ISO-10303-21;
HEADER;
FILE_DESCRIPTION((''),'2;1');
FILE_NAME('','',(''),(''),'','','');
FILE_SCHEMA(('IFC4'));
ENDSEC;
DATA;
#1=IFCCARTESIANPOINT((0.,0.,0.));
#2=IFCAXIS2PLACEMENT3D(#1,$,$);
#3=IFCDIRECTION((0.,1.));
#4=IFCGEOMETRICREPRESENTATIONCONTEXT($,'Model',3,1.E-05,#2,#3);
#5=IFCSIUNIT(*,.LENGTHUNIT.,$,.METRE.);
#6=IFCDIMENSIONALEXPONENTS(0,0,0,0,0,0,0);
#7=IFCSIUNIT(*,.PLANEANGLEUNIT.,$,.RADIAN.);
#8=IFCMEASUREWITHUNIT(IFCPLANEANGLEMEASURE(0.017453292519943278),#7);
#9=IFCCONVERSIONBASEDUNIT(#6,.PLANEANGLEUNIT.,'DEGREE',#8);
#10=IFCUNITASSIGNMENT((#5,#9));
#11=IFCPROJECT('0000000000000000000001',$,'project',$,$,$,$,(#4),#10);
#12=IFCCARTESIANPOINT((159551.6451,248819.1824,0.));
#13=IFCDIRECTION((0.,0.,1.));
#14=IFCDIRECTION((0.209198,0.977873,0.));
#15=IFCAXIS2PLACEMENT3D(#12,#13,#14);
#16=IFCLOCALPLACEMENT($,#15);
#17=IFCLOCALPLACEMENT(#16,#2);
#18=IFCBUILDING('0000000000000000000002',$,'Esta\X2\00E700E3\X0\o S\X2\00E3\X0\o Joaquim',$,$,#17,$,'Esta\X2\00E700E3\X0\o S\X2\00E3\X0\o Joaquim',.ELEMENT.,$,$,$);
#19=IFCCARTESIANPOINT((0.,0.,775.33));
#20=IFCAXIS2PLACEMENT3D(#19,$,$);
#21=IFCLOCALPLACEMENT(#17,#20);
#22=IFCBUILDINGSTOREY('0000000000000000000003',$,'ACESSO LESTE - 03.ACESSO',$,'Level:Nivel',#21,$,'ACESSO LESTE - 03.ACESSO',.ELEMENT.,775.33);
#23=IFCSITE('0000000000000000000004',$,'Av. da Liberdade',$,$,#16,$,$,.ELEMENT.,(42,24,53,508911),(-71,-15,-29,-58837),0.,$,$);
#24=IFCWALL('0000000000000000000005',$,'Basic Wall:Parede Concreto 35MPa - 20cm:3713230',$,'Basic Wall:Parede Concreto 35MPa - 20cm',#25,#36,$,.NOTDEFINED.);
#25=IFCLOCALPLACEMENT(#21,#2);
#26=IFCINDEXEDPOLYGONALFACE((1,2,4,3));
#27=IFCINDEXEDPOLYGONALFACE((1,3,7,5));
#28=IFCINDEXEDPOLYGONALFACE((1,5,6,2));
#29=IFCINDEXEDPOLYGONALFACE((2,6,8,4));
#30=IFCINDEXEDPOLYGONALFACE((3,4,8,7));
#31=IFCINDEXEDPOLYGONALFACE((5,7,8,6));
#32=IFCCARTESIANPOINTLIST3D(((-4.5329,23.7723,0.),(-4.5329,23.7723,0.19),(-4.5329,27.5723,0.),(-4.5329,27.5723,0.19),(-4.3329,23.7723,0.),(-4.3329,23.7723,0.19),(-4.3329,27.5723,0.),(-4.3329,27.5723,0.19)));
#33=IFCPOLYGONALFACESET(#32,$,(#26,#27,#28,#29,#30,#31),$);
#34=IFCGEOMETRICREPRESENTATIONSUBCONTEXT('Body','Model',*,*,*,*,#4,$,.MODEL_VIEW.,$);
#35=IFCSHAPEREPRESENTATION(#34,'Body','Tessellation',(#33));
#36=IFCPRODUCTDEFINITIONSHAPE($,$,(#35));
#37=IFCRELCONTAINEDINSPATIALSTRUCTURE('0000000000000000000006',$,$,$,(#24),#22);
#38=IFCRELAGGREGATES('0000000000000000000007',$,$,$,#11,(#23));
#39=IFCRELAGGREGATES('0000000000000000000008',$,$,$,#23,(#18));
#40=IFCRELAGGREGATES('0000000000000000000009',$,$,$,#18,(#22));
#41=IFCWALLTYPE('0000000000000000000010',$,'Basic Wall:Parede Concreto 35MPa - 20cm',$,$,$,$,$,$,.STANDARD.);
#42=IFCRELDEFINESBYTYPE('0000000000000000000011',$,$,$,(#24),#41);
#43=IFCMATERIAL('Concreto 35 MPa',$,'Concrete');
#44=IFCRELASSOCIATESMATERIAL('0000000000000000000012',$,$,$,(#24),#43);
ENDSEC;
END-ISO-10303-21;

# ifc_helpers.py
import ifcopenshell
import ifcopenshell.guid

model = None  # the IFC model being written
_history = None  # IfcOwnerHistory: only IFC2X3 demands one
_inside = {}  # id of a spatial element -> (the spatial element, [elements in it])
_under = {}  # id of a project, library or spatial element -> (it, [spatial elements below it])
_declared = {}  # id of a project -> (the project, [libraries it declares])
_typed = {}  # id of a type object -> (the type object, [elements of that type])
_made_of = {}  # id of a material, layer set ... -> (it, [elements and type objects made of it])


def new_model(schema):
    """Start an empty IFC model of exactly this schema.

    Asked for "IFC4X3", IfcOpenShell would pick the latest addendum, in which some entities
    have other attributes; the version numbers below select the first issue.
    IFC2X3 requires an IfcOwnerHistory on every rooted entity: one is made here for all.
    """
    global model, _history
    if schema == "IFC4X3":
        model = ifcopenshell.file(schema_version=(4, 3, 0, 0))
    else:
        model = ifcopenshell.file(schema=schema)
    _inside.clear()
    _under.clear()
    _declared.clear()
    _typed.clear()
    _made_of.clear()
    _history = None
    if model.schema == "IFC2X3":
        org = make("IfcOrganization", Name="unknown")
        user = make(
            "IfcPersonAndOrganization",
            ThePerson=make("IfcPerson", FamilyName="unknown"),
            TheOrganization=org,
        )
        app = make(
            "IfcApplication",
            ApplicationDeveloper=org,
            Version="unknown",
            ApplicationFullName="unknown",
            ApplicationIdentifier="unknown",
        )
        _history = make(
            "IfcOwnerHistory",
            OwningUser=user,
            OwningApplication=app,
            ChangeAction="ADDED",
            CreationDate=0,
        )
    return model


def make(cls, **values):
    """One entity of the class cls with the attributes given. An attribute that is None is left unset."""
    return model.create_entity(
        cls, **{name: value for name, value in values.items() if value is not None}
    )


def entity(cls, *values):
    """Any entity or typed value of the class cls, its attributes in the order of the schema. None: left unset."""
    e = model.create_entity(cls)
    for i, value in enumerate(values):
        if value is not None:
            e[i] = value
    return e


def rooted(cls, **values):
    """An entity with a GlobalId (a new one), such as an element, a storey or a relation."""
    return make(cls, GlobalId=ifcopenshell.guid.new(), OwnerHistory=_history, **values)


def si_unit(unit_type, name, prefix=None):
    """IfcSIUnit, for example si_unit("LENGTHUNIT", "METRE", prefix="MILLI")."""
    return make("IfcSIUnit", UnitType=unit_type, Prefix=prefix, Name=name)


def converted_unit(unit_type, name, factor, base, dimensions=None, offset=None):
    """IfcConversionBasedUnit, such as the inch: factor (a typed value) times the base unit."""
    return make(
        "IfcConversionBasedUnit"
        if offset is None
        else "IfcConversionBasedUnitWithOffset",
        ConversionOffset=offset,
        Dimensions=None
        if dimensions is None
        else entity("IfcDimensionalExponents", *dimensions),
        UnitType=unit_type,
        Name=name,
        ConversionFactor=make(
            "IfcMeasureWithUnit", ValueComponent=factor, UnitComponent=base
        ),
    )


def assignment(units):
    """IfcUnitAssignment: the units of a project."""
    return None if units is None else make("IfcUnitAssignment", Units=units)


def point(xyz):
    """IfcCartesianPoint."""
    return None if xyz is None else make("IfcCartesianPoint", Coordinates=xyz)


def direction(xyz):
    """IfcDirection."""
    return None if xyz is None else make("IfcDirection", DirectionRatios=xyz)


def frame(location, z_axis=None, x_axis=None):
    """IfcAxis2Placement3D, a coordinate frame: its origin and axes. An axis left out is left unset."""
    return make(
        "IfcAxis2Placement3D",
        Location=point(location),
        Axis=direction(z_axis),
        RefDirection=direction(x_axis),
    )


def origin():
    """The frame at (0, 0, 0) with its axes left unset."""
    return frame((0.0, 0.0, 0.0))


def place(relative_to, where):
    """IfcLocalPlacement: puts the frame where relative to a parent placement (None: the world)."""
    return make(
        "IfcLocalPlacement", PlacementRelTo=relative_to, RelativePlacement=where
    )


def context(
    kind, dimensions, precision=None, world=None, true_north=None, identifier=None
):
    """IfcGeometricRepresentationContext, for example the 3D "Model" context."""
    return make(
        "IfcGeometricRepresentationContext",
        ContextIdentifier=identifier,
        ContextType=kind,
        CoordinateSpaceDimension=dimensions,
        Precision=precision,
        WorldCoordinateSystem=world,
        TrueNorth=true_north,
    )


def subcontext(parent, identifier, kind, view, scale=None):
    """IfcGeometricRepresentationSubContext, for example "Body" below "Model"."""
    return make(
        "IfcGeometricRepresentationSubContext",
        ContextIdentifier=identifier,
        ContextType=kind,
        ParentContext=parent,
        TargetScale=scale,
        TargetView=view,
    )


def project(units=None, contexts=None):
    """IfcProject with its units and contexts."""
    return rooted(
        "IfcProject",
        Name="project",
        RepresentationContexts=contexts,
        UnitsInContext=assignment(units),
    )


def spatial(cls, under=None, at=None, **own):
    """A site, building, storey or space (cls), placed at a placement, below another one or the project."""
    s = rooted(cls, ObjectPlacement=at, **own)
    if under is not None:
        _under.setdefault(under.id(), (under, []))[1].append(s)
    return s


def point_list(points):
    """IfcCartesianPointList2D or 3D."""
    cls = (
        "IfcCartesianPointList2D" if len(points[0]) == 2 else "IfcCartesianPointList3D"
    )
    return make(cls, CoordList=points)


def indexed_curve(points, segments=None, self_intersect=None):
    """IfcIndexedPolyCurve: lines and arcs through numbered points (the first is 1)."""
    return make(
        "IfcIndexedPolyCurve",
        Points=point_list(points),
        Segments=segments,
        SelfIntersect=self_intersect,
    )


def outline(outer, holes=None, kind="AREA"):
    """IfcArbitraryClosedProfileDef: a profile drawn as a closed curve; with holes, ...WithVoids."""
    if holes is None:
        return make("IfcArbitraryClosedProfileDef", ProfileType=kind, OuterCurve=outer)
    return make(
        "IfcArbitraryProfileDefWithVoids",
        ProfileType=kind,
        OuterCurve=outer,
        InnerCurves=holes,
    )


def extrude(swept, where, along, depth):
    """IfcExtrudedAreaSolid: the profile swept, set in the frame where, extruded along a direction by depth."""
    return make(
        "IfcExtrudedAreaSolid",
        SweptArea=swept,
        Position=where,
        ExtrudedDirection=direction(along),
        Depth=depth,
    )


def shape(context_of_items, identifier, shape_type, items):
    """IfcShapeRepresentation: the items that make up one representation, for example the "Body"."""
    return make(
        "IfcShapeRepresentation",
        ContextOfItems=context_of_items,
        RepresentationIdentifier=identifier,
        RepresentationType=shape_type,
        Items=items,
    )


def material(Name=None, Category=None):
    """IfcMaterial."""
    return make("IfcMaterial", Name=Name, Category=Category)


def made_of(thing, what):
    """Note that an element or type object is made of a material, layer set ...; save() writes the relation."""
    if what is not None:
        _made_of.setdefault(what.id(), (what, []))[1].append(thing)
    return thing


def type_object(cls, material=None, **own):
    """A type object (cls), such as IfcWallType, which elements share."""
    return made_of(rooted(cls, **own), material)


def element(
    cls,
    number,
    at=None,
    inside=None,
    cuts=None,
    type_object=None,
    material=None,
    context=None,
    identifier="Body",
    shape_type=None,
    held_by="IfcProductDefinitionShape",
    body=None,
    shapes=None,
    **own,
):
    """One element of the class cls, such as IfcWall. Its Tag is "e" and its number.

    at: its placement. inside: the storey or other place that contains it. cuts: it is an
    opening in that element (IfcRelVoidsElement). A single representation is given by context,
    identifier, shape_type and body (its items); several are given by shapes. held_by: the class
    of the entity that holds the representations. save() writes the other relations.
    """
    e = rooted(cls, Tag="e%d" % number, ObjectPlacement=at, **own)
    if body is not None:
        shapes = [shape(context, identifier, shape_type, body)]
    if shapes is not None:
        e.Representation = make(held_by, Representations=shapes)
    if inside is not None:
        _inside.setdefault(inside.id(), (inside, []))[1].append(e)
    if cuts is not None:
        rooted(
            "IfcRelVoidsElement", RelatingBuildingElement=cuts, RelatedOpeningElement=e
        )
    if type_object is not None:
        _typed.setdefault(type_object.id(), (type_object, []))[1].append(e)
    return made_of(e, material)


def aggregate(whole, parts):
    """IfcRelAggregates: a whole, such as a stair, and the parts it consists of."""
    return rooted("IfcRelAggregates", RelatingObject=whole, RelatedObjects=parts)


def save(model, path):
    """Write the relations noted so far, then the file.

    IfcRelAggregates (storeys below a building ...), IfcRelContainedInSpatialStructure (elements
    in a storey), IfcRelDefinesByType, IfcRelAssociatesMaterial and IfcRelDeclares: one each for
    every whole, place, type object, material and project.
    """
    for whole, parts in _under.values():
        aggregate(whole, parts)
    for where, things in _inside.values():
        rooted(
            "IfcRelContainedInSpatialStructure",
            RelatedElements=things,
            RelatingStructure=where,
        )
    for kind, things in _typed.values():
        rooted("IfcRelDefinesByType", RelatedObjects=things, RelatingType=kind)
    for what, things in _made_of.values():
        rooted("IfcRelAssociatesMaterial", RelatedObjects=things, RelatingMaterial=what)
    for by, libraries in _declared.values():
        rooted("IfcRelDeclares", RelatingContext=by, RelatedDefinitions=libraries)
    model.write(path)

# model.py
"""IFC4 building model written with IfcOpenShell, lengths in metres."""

from ifc_helpers import new_model, entity, si_unit, converted_unit, direction, frame, origin, place, context, subcontext, project, spatial, indexed_curve, outline, extrude, material, type_object, element, save


model = new_model("IFC4")

# Units and contexts
model_context = context("Model", 3, precision=1e-05, world=origin(), true_north=direction((0.0, 1.0)))
body_context = subcontext(model_context, "Body", "Model", "MODEL_VIEW")
ifc_project = project(units=[si_unit("LENGTHUNIT", "METRE"), converted_unit("PLANEANGLEUNIT", "DEGREE", entity("IfcPlaneAngleMeasure", 0.017453292519943278), si_unit("PLANEANGLEUNIT", "RADIAN"), dimensions=[0, 0, 0, 0, 0, 0, 0])], contexts=[model_context])

# Site, building, storey
site_placement = place(None, frame((159551.6451, 248819.1824, 0.0), z_axis=(0.0, 0.0, 1.0), x_axis=(0.209198, 0.977873, 0.0)))
site = spatial("IfcSite", under=ifc_project, at=site_placement, Name="Av. da Liberdade", CompositionType="ELEMENT", RefLatitude=(42, 24, 53, 508911), RefLongitude=(-71, -15, -29, -58837), RefElevation=0.0)
building_placement = place(site_placement, origin())
building = spatial("IfcBuilding", under=site, at=building_placement, Name="Estação São Joaquim", LongName="Estação São Joaquim", CompositionType="ELEMENT")
storey_placement = place(building_placement, frame((0.0, 0.0, 775.33)))
storey = spatial("IfcBuildingStorey", under=building, at=storey_placement, Name="ACESSO LESTE - 03.ACESSO", ObjectType="Level:Nivel", LongName="ACESSO LESTE - 03.ACESSO", CompositionType="ELEMENT", Elevation=775.33)

# Shared definitions
ifc_material = material(Name="Concreto 35 MPa", Category="Concrete")

# Shared definitions
wall_type = type_object("IfcWallType", Name="Basic Wall:Parede Concreto 35MPa - 20cm", PredefinedType="STANDARD")

# Wall
wall_1_placement = place(storey_placement, frame((-4.4329, 27.5723, 0.0), z_axis=(0.0, 0.0, 1.0), x_axis=(0.0, -1.0, 0.0)))
element("IfcWall", 1, at=wall_1_placement, inside=storey, type_object=wall_type, material=ifc_material, Name="Basic Wall:Parede Concreto 35MPa - 20cm:3713230", ObjectType="Basic Wall:Parede Concreto 35MPa - 20cm", PredefinedType="NOTDEFINED", context=body_context, shape_type="SweptSolid", body=[
    extrude(outline(indexed_curve([(3.8, 0.1), (0.0, 0.1), (0.0, -0.1), (3.8, -0.1), (3.8, 0.1)], self_intersect=False)), origin(), (0.0, 0.0, 1.0), 0.19),
])

save(model, "model.ifc")
